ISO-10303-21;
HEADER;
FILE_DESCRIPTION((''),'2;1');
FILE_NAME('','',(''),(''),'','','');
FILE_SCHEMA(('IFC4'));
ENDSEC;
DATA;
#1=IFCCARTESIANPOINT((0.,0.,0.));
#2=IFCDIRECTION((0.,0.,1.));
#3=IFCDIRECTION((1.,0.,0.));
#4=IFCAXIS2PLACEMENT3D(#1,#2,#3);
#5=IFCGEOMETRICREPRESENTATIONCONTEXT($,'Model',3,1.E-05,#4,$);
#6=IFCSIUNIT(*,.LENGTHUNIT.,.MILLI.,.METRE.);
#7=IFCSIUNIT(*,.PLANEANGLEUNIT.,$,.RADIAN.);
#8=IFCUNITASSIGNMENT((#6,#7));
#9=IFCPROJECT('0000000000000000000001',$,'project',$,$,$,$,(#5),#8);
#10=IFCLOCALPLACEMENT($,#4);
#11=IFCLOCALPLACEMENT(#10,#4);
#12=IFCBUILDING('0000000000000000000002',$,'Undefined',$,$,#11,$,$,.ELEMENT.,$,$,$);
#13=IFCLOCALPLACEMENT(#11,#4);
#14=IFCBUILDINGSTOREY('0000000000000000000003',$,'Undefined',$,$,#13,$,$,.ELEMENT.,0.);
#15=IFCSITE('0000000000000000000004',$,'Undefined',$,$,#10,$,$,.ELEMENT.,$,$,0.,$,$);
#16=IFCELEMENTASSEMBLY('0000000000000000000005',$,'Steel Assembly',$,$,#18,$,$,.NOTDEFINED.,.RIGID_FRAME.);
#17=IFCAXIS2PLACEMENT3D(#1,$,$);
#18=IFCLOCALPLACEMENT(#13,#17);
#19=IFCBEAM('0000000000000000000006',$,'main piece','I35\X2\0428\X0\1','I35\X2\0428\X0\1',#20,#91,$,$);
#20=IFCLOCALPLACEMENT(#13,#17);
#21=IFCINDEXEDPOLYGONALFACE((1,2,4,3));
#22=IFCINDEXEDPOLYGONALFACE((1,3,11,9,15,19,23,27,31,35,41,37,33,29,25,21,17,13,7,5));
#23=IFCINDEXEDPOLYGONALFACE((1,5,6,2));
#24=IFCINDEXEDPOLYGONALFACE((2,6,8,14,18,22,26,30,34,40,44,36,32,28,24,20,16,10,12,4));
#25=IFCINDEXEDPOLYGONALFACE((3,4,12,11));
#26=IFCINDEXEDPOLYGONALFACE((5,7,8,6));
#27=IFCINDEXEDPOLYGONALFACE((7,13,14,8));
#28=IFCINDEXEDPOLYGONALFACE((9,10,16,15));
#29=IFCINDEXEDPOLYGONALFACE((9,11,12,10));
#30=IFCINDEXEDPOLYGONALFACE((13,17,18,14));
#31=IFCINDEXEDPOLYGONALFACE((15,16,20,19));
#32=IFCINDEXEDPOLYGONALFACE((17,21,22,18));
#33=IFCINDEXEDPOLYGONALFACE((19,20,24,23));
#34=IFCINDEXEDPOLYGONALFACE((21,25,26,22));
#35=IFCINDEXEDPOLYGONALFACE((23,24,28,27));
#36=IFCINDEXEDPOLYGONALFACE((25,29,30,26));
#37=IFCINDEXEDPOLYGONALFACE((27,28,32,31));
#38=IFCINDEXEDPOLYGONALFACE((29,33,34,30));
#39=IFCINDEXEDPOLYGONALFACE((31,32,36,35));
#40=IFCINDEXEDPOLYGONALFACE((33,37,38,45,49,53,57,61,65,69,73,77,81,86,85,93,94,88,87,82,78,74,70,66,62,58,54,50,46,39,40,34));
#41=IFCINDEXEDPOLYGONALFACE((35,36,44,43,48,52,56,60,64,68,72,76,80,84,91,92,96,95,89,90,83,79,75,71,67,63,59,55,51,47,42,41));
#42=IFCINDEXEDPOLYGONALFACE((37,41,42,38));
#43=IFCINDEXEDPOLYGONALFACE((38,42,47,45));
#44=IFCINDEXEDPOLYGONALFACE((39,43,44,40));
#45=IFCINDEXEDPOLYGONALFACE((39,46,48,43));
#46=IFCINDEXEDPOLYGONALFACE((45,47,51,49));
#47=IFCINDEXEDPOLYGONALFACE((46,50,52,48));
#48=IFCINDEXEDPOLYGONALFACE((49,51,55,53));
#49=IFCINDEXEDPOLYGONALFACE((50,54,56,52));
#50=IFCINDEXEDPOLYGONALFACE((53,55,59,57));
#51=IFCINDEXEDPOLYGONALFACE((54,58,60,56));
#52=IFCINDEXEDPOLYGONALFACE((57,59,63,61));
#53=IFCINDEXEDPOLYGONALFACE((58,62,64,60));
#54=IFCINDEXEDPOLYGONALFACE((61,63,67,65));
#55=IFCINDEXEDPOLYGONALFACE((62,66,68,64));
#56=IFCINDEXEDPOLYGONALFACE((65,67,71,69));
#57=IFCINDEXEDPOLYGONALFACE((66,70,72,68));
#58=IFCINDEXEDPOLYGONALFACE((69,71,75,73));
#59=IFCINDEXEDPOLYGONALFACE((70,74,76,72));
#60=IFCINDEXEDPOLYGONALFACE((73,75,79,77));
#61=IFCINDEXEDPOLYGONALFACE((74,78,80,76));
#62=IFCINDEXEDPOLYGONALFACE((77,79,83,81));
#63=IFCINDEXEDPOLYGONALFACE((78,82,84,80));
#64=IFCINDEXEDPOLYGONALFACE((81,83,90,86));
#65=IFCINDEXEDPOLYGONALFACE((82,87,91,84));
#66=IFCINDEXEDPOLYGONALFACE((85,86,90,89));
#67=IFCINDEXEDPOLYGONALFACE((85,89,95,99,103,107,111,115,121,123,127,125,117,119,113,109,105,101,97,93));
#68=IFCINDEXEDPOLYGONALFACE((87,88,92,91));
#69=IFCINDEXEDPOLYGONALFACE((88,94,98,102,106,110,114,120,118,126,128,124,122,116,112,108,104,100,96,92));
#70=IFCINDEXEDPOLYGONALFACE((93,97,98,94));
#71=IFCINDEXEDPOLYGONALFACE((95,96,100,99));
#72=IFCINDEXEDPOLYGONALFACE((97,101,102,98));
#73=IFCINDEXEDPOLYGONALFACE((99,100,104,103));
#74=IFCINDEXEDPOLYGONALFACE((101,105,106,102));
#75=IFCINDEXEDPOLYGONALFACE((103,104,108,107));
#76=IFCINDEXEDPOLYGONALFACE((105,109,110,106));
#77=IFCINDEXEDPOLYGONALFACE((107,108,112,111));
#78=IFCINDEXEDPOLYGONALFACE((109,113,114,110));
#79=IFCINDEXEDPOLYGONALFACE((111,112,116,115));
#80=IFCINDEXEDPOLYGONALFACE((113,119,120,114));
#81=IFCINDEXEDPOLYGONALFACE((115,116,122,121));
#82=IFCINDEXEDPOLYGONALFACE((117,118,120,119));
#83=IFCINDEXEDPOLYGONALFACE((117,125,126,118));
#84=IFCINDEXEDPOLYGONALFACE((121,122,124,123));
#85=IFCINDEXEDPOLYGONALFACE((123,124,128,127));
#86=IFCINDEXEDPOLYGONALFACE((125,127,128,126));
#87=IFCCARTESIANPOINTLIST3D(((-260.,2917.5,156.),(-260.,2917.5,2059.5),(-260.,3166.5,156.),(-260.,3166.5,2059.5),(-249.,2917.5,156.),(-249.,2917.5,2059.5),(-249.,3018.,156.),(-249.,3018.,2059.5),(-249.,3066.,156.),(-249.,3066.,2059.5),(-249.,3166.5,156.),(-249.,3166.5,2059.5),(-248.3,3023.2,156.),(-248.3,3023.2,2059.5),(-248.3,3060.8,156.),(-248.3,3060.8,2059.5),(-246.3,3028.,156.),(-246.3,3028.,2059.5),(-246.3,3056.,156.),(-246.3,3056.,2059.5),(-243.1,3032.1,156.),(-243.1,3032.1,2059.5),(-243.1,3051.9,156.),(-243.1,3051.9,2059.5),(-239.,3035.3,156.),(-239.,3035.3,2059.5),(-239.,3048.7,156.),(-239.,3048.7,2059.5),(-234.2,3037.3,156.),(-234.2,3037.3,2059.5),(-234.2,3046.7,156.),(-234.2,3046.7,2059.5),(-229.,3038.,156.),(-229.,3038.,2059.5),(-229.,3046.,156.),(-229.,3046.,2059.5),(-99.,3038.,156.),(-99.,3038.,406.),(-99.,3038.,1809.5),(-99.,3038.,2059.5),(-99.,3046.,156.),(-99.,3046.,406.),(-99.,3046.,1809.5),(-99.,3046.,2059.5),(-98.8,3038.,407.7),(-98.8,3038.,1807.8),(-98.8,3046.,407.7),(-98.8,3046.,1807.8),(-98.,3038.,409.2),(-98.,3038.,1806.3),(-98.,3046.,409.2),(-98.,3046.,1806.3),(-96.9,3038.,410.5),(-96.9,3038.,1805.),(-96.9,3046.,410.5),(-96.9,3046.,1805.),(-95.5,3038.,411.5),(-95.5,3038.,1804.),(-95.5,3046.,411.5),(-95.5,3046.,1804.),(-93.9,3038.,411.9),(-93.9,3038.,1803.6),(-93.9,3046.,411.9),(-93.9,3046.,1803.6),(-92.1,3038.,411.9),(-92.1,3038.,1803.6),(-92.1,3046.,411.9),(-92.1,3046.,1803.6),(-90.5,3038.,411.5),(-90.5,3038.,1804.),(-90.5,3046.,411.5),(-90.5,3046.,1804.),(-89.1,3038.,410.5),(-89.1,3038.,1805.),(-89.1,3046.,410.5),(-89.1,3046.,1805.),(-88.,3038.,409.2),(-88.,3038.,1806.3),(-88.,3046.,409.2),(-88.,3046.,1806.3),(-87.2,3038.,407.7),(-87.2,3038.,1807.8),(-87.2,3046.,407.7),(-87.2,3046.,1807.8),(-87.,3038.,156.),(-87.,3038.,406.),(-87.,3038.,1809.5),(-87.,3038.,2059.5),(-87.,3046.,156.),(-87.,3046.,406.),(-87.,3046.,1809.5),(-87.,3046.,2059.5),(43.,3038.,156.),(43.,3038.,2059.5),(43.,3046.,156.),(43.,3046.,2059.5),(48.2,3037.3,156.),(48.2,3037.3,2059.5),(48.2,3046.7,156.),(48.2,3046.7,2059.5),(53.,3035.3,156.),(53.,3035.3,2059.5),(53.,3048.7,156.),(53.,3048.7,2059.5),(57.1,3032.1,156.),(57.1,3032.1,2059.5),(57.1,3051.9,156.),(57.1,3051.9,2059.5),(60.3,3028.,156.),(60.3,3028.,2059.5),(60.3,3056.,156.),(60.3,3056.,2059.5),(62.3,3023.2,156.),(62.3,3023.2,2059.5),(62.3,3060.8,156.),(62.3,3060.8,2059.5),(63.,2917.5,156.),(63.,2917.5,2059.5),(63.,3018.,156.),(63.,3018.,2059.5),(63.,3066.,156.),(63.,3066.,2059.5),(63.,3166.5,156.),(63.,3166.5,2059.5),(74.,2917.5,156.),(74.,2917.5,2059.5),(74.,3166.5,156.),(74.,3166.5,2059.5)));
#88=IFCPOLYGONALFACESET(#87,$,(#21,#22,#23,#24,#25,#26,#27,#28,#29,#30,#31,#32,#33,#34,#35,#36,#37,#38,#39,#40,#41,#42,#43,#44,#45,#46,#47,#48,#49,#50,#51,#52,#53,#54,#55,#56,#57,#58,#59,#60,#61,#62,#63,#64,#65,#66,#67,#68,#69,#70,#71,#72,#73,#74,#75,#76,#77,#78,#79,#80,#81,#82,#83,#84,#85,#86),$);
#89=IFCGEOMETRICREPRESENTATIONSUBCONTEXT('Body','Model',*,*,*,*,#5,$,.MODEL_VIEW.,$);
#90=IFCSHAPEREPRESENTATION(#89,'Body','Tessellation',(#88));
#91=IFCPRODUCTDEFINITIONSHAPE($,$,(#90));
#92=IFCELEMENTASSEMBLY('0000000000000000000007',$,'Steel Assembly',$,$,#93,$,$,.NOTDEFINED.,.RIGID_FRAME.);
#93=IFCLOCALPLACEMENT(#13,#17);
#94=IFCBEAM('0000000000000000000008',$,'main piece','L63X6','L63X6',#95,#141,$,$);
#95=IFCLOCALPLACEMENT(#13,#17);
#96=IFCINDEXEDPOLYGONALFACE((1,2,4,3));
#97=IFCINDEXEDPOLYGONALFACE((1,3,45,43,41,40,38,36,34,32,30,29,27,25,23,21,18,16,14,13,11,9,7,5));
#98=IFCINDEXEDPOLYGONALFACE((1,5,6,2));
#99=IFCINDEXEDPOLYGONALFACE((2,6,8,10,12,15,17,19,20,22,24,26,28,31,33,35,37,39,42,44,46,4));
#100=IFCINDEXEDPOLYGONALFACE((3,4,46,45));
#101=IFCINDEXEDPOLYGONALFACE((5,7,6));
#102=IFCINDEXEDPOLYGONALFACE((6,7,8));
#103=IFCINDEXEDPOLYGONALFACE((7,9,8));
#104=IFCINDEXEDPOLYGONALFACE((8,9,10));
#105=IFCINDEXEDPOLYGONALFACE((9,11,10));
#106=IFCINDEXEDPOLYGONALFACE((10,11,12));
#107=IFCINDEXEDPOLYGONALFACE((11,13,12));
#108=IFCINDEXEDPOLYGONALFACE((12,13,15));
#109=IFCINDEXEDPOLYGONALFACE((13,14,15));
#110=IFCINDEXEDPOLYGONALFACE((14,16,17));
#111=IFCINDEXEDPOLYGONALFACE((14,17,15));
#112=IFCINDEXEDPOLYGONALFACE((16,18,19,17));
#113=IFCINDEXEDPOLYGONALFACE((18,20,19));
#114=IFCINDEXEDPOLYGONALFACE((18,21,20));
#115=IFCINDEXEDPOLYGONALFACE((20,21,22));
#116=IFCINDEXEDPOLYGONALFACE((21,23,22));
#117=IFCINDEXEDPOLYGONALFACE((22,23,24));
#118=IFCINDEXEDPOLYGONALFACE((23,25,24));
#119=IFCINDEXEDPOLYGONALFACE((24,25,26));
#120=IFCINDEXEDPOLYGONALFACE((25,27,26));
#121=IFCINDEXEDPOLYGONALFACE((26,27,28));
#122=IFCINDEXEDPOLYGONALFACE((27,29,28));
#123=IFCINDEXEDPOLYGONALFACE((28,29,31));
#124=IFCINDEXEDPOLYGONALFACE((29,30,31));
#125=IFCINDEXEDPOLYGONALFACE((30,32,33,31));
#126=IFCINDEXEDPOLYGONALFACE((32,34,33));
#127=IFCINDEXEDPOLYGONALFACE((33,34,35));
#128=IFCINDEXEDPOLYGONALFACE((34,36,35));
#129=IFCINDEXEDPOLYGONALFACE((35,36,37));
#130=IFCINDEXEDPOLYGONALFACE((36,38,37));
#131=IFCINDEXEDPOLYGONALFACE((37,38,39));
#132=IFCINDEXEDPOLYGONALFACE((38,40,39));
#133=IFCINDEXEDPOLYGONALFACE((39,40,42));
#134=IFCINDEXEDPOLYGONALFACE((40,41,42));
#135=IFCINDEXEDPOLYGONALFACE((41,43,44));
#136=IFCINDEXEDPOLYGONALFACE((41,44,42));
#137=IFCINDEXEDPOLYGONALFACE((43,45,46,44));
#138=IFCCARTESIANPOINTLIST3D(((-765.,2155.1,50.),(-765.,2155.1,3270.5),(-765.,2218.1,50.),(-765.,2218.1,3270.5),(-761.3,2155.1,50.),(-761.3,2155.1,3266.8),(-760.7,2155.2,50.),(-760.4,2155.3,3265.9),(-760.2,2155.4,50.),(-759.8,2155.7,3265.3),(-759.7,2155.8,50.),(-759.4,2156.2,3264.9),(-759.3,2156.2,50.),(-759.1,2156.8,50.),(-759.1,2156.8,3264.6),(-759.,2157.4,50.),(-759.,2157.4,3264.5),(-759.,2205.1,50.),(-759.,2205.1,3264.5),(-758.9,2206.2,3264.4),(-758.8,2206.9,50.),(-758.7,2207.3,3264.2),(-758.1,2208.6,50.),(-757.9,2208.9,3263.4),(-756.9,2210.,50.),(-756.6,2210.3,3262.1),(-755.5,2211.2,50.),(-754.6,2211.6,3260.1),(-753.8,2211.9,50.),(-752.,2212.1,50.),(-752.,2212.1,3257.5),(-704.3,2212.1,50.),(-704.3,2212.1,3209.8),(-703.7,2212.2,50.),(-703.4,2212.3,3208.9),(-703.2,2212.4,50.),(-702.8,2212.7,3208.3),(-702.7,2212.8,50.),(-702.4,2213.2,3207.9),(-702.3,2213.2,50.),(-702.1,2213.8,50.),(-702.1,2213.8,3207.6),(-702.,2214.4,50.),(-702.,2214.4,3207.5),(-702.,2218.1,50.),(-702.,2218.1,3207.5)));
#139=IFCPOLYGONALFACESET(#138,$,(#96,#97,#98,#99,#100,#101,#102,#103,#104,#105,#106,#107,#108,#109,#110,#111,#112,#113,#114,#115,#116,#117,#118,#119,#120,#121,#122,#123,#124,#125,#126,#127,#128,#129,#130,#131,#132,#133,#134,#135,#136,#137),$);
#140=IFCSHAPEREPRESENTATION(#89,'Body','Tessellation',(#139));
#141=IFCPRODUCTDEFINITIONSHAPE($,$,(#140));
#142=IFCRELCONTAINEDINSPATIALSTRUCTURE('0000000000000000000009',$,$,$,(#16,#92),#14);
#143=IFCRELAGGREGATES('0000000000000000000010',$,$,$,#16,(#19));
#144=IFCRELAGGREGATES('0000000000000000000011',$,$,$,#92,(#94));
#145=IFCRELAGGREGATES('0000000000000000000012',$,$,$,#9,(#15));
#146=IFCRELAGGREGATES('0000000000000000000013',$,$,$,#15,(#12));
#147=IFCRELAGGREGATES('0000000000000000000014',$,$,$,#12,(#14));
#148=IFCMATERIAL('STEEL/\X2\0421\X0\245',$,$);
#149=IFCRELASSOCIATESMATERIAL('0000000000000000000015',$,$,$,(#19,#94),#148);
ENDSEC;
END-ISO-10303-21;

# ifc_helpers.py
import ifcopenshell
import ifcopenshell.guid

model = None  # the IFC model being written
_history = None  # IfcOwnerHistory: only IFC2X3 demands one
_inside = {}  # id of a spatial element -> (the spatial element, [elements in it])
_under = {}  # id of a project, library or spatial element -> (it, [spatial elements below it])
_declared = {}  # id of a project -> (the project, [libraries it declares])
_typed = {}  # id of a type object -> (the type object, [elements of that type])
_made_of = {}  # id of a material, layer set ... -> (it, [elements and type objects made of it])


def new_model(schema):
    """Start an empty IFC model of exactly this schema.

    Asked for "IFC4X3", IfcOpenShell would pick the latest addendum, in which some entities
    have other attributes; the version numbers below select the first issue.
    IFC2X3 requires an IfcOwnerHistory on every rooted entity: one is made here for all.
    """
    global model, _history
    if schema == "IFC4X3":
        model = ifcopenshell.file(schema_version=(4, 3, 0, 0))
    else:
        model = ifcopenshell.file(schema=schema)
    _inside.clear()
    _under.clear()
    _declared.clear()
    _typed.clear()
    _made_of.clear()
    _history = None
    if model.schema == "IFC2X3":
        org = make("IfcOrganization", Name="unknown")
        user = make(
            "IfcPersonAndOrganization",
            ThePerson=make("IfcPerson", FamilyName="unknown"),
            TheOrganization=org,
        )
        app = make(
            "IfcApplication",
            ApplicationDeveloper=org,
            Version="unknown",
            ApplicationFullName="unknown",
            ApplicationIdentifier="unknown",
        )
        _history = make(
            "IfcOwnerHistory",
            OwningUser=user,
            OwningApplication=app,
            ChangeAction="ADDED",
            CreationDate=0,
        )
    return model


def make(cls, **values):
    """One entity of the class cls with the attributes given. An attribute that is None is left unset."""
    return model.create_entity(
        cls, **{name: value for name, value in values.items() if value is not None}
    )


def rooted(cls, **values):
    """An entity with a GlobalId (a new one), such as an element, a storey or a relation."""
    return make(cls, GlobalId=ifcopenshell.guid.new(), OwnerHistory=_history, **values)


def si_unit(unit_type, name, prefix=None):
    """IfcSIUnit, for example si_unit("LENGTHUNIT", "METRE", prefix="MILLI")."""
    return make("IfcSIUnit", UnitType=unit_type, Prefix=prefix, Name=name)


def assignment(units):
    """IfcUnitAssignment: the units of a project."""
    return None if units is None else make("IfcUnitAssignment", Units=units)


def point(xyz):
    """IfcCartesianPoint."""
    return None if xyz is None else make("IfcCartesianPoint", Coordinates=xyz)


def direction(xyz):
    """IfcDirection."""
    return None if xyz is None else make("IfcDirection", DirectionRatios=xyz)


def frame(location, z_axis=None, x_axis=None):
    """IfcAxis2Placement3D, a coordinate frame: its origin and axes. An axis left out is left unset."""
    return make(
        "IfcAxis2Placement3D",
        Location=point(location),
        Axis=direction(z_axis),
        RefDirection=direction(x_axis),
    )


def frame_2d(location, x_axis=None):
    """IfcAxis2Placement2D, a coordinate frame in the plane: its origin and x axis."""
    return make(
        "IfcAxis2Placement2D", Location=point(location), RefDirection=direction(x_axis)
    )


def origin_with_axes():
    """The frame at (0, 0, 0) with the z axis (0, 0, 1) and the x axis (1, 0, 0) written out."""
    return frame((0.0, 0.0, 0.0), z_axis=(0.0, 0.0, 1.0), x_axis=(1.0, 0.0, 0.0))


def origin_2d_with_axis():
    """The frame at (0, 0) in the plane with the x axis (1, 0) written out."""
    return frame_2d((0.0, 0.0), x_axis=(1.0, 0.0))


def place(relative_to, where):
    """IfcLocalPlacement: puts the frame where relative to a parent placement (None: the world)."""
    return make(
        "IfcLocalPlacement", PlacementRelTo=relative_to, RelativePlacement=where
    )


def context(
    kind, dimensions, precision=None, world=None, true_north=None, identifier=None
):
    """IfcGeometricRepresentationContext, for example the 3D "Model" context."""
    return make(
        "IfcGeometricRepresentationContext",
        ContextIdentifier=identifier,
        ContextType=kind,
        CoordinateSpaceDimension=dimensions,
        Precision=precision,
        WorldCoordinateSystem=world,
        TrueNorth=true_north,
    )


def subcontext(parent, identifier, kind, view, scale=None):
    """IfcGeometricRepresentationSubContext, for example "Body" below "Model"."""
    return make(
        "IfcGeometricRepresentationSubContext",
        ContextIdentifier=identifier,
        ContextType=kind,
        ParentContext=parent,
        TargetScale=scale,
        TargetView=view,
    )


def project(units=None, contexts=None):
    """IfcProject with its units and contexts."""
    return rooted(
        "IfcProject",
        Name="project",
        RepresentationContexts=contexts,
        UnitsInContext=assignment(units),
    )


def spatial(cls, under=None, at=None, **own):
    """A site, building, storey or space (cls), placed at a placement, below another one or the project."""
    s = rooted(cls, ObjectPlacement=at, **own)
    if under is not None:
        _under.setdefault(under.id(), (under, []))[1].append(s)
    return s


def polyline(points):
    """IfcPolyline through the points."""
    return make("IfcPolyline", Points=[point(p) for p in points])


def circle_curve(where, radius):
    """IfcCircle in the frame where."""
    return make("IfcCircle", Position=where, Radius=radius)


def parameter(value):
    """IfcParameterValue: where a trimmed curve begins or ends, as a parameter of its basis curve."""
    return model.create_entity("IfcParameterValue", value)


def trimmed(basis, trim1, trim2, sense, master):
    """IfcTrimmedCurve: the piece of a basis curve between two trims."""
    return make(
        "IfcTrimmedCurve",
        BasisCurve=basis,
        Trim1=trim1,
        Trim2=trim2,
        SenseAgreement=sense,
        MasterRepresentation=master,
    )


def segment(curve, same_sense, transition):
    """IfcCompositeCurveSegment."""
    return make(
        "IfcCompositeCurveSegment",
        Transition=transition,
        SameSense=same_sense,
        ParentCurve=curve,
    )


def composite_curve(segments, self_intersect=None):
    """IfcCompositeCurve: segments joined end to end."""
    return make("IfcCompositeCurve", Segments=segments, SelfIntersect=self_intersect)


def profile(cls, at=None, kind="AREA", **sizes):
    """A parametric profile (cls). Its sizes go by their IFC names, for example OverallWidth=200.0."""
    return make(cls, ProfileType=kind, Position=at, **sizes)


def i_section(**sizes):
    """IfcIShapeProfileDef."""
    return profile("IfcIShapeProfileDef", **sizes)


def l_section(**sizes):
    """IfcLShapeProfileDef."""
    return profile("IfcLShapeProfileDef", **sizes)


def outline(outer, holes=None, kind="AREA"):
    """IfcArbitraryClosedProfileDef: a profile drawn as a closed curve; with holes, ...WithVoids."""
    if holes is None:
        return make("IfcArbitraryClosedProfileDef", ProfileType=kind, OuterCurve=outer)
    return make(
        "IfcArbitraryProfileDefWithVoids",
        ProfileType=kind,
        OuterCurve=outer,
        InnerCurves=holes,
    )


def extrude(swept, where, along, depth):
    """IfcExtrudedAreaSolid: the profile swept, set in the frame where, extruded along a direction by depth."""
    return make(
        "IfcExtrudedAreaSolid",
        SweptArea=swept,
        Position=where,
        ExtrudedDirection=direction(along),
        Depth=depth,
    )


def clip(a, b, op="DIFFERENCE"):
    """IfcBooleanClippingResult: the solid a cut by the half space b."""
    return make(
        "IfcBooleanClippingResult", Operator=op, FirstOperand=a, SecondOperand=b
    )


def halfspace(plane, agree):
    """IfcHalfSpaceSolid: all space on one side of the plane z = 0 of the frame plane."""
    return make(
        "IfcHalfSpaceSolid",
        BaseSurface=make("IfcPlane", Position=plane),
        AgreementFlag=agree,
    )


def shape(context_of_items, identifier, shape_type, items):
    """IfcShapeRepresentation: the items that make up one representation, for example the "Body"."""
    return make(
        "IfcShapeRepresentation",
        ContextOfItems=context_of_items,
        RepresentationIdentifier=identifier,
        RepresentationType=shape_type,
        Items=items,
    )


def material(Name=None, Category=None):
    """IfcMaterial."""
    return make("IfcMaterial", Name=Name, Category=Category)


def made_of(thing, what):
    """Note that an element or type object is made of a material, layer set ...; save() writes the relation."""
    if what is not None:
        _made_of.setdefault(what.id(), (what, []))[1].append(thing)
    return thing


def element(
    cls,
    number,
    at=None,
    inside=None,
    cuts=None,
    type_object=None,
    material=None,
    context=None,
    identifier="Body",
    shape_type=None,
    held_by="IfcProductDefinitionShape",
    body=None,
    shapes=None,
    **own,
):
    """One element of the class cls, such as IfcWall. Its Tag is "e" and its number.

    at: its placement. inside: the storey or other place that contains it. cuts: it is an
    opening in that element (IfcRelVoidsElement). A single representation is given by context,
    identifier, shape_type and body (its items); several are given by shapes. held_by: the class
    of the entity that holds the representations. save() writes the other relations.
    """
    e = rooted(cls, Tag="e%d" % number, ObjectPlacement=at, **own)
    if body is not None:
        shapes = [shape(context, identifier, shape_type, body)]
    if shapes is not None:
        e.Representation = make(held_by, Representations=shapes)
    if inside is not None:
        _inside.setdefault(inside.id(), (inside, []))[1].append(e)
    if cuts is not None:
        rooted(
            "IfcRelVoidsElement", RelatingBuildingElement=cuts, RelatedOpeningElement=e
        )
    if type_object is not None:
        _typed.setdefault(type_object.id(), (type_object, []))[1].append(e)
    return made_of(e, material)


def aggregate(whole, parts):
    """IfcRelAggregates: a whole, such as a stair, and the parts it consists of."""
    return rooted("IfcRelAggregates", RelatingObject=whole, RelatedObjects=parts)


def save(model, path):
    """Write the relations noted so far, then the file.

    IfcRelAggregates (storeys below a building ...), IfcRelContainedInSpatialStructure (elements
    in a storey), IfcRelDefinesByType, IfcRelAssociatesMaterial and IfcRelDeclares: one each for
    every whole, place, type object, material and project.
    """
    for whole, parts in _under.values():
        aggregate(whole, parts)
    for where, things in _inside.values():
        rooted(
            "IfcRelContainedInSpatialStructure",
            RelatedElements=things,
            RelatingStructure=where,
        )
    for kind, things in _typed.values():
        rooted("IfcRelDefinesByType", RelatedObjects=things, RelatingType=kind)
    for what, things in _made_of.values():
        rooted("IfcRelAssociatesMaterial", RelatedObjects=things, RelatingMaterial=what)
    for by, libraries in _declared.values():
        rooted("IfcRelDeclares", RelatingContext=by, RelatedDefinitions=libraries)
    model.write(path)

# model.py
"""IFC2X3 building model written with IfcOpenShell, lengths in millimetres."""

from ifc_helpers import new_model, si_unit, frame, frame_2d, origin_with_axes, origin_2d_with_axis, place, context, subcontext, project, spatial, polyline, circle_curve, parameter, trimmed, segment, composite_curve, i_section, l_section, outline, extrude, clip, halfspace, material, element, aggregate, save


model = new_model("IFC2X3")

# Units and contexts
model_context = context("Model", 3, precision=1e-05, world=origin_with_axes())
body_context = subcontext(model_context, "Body", "Model", "MODEL_VIEW")
ifc_project = project(units=[si_unit("LENGTHUNIT", "METRE", prefix="MILLI"), si_unit("PLANEANGLEUNIT", "RADIAN")], contexts=[model_context])

# Site, building, storey
site_placement = place(None, origin_with_axes())
site = spatial("IfcSite", under=ifc_project, at=site_placement, Name="Undefined", CompositionType="ELEMENT", RefElevation=0.0)
building_placement = place(site_placement, origin_with_axes())
building = spatial("IfcBuilding", under=site, at=building_placement, Name="Undefined", CompositionType="ELEMENT")
storey_placement = place(building_placement, origin_with_axes())
storey = spatial("IfcBuildingStorey", under=building, at=storey_placement, Name="Undefined", CompositionType="ELEMENT", Elevation=0.0)

# Element assembly, beam, openings
assembly_1_placement = place(storey_placement, origin_with_axes())
assembly_1 = element("IfcElementAssembly", 1, at=assembly_1_placement, inside=storey, Name="Steel Assembly", AssemblyPlace="NOTDEFINED", PredefinedType="RIGID_FRAME")
ifc_material_1 = material(Name="STEEL/С245")
beam_1_placement = place(assembly_1_placement, frame((-93.0, 3042.0, 2059.5), z_axis=(-1.0, 0.0, 0.0), x_axis=(0.0, 0.0, -1.0)))
beam_1 = element("IfcBeam", 2, at=beam_1_placement, material=ifc_material_1, Name="main piece", Description="I35Ш1", ObjectType="I35Ш1", context=body_context, shape_type="Clipping", body=[
    clip(clip(extrude(i_section(OverallWidth=249.0, OverallDepth=334.0, WebThickness=8.0, FlangeThickness=11.0, FilletRadius=20.0, at=origin_2d_with_axis()), frame((1903.5, 0.0, 0.0), z_axis=(-1.0, 0.0, 0.0), x_axis=(0.0, -1.0, 0.0)), (0.0, 0.0, 1.0), 1903.5), halfspace(frame((1903.5, 0.6, 274.0), z_axis=(-1.0, 0.0, 0.0), x_axis=(0.0, -1.0, 0.0)), True)), halfspace(frame((0.0, -0.6, 274.0), z_axis=(1.0, 0.0, 0.0), x_axis=(0.0, 1.0, 0.0)), True)),
])
opening_1_placement = place(assembly_1_placement, frame((-93.0, 3042.0, 2059.5), z_axis=(-1.0, 0.0, 0.0), x_axis=(0.0, 0.0, -1.0)))
element("IfcOpeningElement", 3, at=opening_1_placement, cuts=beam_1, ObjectType="Recess", context=body_context, shape_type="SweptSolid", body=[
    extrude(outline(composite_curve([segment(polyline([(0.0, 0.0), (250.0, 0.0)]), True, "CONTINUOUS"), segment(trimmed(circle_curve(frame_2d((250.0, 6.0), x_axis=(-0.000939, -1.0)), 6.0), [parameter(0.0)], [parameter(3.14347)], True, "PARAMETER"), True, "CONTINUOUS"), segment(polyline([(250.0, 12.0), (0.0, 12.0), (0.0, 0.0)]), True, "DISCONTINUOUS")], self_intersect=False)), frame((0.0, 102.5, -6.0), z_axis=(0.0, -1.0, 0.0), x_axis=(1.0, 0.0, 0.0)), (0.0, 0.0, 1.0), 205.0),
])
opening_2_placement = place(assembly_1_placement, frame((-93.0, 3042.0, 2059.5), z_axis=(-1.0, 0.0, 0.0), x_axis=(0.0, 0.0, -1.0)))
element("IfcOpeningElement", 4, at=opening_2_placement, cuts=beam_1, ObjectType="Recess", context=body_context, shape_type="SweptSolid", body=[
    extrude(outline(composite_curve([segment(polyline([(0.0, 0.0), (250.0, 0.0)]), True, "CONTINUOUS"), segment(trimmed(circle_curve(frame_2d((250.0, 6.0), x_axis=(-0.000939, -1.0)), 6.0), [parameter(0.0)], [parameter(3.14347)], True, "PARAMETER"), True, "CONTINUOUS"), segment(polyline([(250.0, 12.0), (0.0, 12.0), (0.0, 0.0)]), True, "DISCONTINUOUS")], self_intersect=False)), frame((1903.5, -102.5, -6.0), z_axis=(0.0, 1.0, 0.0), x_axis=(-1.0, 0.0, 0.0)), (0.0, 0.0, 1.0), 205.0),
])

# Element assembly, beam
assembly_2_placement = place(storey_placement, origin_with_axes())
assembly_2 = element("IfcElementAssembly", 5, at=assembly_2_placement, inside=storey, Name="Steel Assembly", AssemblyPlace="NOTDEFINED", PredefinedType="RIGID_FRAME")
beam_2_placement = place(assembly_2_placement, frame((-733.5, 2186.6, 3270.5), z_axis=(1.0, 0.0, 0.0), x_axis=(0.0, 0.0, -1.0)))
beam_2 = element("IfcBeam", 6, at=beam_2_placement, material=ifc_material_1, Name="main piece", Description="L63X6", ObjectType="L63X6", context=body_context, shape_type="Clipping", body=[
    clip(extrude(l_section(Depth=63.0, Width=63.0, Thickness=6.0, FilletRadius=7.0, EdgeRadius=2.3, at=origin_2d_with_axis()), frame((3220.5, 0.0, 0.0), z_axis=(-1.0, 0.0, 0.0), x_axis=(0.0, -1.0, 0.0)), (0.0, 0.0, 1.0), 3220.8), halfspace(frame((63.0, 31.5, 31.5), z_axis=(-0.707107, 0.0, 0.707107), x_axis=(0.0, -1.0, 0.0)), False)),
])

aggregate(assembly_1, [beam_1])

aggregate(assembly_2, [beam_2])

save(model, "model.ifc")
